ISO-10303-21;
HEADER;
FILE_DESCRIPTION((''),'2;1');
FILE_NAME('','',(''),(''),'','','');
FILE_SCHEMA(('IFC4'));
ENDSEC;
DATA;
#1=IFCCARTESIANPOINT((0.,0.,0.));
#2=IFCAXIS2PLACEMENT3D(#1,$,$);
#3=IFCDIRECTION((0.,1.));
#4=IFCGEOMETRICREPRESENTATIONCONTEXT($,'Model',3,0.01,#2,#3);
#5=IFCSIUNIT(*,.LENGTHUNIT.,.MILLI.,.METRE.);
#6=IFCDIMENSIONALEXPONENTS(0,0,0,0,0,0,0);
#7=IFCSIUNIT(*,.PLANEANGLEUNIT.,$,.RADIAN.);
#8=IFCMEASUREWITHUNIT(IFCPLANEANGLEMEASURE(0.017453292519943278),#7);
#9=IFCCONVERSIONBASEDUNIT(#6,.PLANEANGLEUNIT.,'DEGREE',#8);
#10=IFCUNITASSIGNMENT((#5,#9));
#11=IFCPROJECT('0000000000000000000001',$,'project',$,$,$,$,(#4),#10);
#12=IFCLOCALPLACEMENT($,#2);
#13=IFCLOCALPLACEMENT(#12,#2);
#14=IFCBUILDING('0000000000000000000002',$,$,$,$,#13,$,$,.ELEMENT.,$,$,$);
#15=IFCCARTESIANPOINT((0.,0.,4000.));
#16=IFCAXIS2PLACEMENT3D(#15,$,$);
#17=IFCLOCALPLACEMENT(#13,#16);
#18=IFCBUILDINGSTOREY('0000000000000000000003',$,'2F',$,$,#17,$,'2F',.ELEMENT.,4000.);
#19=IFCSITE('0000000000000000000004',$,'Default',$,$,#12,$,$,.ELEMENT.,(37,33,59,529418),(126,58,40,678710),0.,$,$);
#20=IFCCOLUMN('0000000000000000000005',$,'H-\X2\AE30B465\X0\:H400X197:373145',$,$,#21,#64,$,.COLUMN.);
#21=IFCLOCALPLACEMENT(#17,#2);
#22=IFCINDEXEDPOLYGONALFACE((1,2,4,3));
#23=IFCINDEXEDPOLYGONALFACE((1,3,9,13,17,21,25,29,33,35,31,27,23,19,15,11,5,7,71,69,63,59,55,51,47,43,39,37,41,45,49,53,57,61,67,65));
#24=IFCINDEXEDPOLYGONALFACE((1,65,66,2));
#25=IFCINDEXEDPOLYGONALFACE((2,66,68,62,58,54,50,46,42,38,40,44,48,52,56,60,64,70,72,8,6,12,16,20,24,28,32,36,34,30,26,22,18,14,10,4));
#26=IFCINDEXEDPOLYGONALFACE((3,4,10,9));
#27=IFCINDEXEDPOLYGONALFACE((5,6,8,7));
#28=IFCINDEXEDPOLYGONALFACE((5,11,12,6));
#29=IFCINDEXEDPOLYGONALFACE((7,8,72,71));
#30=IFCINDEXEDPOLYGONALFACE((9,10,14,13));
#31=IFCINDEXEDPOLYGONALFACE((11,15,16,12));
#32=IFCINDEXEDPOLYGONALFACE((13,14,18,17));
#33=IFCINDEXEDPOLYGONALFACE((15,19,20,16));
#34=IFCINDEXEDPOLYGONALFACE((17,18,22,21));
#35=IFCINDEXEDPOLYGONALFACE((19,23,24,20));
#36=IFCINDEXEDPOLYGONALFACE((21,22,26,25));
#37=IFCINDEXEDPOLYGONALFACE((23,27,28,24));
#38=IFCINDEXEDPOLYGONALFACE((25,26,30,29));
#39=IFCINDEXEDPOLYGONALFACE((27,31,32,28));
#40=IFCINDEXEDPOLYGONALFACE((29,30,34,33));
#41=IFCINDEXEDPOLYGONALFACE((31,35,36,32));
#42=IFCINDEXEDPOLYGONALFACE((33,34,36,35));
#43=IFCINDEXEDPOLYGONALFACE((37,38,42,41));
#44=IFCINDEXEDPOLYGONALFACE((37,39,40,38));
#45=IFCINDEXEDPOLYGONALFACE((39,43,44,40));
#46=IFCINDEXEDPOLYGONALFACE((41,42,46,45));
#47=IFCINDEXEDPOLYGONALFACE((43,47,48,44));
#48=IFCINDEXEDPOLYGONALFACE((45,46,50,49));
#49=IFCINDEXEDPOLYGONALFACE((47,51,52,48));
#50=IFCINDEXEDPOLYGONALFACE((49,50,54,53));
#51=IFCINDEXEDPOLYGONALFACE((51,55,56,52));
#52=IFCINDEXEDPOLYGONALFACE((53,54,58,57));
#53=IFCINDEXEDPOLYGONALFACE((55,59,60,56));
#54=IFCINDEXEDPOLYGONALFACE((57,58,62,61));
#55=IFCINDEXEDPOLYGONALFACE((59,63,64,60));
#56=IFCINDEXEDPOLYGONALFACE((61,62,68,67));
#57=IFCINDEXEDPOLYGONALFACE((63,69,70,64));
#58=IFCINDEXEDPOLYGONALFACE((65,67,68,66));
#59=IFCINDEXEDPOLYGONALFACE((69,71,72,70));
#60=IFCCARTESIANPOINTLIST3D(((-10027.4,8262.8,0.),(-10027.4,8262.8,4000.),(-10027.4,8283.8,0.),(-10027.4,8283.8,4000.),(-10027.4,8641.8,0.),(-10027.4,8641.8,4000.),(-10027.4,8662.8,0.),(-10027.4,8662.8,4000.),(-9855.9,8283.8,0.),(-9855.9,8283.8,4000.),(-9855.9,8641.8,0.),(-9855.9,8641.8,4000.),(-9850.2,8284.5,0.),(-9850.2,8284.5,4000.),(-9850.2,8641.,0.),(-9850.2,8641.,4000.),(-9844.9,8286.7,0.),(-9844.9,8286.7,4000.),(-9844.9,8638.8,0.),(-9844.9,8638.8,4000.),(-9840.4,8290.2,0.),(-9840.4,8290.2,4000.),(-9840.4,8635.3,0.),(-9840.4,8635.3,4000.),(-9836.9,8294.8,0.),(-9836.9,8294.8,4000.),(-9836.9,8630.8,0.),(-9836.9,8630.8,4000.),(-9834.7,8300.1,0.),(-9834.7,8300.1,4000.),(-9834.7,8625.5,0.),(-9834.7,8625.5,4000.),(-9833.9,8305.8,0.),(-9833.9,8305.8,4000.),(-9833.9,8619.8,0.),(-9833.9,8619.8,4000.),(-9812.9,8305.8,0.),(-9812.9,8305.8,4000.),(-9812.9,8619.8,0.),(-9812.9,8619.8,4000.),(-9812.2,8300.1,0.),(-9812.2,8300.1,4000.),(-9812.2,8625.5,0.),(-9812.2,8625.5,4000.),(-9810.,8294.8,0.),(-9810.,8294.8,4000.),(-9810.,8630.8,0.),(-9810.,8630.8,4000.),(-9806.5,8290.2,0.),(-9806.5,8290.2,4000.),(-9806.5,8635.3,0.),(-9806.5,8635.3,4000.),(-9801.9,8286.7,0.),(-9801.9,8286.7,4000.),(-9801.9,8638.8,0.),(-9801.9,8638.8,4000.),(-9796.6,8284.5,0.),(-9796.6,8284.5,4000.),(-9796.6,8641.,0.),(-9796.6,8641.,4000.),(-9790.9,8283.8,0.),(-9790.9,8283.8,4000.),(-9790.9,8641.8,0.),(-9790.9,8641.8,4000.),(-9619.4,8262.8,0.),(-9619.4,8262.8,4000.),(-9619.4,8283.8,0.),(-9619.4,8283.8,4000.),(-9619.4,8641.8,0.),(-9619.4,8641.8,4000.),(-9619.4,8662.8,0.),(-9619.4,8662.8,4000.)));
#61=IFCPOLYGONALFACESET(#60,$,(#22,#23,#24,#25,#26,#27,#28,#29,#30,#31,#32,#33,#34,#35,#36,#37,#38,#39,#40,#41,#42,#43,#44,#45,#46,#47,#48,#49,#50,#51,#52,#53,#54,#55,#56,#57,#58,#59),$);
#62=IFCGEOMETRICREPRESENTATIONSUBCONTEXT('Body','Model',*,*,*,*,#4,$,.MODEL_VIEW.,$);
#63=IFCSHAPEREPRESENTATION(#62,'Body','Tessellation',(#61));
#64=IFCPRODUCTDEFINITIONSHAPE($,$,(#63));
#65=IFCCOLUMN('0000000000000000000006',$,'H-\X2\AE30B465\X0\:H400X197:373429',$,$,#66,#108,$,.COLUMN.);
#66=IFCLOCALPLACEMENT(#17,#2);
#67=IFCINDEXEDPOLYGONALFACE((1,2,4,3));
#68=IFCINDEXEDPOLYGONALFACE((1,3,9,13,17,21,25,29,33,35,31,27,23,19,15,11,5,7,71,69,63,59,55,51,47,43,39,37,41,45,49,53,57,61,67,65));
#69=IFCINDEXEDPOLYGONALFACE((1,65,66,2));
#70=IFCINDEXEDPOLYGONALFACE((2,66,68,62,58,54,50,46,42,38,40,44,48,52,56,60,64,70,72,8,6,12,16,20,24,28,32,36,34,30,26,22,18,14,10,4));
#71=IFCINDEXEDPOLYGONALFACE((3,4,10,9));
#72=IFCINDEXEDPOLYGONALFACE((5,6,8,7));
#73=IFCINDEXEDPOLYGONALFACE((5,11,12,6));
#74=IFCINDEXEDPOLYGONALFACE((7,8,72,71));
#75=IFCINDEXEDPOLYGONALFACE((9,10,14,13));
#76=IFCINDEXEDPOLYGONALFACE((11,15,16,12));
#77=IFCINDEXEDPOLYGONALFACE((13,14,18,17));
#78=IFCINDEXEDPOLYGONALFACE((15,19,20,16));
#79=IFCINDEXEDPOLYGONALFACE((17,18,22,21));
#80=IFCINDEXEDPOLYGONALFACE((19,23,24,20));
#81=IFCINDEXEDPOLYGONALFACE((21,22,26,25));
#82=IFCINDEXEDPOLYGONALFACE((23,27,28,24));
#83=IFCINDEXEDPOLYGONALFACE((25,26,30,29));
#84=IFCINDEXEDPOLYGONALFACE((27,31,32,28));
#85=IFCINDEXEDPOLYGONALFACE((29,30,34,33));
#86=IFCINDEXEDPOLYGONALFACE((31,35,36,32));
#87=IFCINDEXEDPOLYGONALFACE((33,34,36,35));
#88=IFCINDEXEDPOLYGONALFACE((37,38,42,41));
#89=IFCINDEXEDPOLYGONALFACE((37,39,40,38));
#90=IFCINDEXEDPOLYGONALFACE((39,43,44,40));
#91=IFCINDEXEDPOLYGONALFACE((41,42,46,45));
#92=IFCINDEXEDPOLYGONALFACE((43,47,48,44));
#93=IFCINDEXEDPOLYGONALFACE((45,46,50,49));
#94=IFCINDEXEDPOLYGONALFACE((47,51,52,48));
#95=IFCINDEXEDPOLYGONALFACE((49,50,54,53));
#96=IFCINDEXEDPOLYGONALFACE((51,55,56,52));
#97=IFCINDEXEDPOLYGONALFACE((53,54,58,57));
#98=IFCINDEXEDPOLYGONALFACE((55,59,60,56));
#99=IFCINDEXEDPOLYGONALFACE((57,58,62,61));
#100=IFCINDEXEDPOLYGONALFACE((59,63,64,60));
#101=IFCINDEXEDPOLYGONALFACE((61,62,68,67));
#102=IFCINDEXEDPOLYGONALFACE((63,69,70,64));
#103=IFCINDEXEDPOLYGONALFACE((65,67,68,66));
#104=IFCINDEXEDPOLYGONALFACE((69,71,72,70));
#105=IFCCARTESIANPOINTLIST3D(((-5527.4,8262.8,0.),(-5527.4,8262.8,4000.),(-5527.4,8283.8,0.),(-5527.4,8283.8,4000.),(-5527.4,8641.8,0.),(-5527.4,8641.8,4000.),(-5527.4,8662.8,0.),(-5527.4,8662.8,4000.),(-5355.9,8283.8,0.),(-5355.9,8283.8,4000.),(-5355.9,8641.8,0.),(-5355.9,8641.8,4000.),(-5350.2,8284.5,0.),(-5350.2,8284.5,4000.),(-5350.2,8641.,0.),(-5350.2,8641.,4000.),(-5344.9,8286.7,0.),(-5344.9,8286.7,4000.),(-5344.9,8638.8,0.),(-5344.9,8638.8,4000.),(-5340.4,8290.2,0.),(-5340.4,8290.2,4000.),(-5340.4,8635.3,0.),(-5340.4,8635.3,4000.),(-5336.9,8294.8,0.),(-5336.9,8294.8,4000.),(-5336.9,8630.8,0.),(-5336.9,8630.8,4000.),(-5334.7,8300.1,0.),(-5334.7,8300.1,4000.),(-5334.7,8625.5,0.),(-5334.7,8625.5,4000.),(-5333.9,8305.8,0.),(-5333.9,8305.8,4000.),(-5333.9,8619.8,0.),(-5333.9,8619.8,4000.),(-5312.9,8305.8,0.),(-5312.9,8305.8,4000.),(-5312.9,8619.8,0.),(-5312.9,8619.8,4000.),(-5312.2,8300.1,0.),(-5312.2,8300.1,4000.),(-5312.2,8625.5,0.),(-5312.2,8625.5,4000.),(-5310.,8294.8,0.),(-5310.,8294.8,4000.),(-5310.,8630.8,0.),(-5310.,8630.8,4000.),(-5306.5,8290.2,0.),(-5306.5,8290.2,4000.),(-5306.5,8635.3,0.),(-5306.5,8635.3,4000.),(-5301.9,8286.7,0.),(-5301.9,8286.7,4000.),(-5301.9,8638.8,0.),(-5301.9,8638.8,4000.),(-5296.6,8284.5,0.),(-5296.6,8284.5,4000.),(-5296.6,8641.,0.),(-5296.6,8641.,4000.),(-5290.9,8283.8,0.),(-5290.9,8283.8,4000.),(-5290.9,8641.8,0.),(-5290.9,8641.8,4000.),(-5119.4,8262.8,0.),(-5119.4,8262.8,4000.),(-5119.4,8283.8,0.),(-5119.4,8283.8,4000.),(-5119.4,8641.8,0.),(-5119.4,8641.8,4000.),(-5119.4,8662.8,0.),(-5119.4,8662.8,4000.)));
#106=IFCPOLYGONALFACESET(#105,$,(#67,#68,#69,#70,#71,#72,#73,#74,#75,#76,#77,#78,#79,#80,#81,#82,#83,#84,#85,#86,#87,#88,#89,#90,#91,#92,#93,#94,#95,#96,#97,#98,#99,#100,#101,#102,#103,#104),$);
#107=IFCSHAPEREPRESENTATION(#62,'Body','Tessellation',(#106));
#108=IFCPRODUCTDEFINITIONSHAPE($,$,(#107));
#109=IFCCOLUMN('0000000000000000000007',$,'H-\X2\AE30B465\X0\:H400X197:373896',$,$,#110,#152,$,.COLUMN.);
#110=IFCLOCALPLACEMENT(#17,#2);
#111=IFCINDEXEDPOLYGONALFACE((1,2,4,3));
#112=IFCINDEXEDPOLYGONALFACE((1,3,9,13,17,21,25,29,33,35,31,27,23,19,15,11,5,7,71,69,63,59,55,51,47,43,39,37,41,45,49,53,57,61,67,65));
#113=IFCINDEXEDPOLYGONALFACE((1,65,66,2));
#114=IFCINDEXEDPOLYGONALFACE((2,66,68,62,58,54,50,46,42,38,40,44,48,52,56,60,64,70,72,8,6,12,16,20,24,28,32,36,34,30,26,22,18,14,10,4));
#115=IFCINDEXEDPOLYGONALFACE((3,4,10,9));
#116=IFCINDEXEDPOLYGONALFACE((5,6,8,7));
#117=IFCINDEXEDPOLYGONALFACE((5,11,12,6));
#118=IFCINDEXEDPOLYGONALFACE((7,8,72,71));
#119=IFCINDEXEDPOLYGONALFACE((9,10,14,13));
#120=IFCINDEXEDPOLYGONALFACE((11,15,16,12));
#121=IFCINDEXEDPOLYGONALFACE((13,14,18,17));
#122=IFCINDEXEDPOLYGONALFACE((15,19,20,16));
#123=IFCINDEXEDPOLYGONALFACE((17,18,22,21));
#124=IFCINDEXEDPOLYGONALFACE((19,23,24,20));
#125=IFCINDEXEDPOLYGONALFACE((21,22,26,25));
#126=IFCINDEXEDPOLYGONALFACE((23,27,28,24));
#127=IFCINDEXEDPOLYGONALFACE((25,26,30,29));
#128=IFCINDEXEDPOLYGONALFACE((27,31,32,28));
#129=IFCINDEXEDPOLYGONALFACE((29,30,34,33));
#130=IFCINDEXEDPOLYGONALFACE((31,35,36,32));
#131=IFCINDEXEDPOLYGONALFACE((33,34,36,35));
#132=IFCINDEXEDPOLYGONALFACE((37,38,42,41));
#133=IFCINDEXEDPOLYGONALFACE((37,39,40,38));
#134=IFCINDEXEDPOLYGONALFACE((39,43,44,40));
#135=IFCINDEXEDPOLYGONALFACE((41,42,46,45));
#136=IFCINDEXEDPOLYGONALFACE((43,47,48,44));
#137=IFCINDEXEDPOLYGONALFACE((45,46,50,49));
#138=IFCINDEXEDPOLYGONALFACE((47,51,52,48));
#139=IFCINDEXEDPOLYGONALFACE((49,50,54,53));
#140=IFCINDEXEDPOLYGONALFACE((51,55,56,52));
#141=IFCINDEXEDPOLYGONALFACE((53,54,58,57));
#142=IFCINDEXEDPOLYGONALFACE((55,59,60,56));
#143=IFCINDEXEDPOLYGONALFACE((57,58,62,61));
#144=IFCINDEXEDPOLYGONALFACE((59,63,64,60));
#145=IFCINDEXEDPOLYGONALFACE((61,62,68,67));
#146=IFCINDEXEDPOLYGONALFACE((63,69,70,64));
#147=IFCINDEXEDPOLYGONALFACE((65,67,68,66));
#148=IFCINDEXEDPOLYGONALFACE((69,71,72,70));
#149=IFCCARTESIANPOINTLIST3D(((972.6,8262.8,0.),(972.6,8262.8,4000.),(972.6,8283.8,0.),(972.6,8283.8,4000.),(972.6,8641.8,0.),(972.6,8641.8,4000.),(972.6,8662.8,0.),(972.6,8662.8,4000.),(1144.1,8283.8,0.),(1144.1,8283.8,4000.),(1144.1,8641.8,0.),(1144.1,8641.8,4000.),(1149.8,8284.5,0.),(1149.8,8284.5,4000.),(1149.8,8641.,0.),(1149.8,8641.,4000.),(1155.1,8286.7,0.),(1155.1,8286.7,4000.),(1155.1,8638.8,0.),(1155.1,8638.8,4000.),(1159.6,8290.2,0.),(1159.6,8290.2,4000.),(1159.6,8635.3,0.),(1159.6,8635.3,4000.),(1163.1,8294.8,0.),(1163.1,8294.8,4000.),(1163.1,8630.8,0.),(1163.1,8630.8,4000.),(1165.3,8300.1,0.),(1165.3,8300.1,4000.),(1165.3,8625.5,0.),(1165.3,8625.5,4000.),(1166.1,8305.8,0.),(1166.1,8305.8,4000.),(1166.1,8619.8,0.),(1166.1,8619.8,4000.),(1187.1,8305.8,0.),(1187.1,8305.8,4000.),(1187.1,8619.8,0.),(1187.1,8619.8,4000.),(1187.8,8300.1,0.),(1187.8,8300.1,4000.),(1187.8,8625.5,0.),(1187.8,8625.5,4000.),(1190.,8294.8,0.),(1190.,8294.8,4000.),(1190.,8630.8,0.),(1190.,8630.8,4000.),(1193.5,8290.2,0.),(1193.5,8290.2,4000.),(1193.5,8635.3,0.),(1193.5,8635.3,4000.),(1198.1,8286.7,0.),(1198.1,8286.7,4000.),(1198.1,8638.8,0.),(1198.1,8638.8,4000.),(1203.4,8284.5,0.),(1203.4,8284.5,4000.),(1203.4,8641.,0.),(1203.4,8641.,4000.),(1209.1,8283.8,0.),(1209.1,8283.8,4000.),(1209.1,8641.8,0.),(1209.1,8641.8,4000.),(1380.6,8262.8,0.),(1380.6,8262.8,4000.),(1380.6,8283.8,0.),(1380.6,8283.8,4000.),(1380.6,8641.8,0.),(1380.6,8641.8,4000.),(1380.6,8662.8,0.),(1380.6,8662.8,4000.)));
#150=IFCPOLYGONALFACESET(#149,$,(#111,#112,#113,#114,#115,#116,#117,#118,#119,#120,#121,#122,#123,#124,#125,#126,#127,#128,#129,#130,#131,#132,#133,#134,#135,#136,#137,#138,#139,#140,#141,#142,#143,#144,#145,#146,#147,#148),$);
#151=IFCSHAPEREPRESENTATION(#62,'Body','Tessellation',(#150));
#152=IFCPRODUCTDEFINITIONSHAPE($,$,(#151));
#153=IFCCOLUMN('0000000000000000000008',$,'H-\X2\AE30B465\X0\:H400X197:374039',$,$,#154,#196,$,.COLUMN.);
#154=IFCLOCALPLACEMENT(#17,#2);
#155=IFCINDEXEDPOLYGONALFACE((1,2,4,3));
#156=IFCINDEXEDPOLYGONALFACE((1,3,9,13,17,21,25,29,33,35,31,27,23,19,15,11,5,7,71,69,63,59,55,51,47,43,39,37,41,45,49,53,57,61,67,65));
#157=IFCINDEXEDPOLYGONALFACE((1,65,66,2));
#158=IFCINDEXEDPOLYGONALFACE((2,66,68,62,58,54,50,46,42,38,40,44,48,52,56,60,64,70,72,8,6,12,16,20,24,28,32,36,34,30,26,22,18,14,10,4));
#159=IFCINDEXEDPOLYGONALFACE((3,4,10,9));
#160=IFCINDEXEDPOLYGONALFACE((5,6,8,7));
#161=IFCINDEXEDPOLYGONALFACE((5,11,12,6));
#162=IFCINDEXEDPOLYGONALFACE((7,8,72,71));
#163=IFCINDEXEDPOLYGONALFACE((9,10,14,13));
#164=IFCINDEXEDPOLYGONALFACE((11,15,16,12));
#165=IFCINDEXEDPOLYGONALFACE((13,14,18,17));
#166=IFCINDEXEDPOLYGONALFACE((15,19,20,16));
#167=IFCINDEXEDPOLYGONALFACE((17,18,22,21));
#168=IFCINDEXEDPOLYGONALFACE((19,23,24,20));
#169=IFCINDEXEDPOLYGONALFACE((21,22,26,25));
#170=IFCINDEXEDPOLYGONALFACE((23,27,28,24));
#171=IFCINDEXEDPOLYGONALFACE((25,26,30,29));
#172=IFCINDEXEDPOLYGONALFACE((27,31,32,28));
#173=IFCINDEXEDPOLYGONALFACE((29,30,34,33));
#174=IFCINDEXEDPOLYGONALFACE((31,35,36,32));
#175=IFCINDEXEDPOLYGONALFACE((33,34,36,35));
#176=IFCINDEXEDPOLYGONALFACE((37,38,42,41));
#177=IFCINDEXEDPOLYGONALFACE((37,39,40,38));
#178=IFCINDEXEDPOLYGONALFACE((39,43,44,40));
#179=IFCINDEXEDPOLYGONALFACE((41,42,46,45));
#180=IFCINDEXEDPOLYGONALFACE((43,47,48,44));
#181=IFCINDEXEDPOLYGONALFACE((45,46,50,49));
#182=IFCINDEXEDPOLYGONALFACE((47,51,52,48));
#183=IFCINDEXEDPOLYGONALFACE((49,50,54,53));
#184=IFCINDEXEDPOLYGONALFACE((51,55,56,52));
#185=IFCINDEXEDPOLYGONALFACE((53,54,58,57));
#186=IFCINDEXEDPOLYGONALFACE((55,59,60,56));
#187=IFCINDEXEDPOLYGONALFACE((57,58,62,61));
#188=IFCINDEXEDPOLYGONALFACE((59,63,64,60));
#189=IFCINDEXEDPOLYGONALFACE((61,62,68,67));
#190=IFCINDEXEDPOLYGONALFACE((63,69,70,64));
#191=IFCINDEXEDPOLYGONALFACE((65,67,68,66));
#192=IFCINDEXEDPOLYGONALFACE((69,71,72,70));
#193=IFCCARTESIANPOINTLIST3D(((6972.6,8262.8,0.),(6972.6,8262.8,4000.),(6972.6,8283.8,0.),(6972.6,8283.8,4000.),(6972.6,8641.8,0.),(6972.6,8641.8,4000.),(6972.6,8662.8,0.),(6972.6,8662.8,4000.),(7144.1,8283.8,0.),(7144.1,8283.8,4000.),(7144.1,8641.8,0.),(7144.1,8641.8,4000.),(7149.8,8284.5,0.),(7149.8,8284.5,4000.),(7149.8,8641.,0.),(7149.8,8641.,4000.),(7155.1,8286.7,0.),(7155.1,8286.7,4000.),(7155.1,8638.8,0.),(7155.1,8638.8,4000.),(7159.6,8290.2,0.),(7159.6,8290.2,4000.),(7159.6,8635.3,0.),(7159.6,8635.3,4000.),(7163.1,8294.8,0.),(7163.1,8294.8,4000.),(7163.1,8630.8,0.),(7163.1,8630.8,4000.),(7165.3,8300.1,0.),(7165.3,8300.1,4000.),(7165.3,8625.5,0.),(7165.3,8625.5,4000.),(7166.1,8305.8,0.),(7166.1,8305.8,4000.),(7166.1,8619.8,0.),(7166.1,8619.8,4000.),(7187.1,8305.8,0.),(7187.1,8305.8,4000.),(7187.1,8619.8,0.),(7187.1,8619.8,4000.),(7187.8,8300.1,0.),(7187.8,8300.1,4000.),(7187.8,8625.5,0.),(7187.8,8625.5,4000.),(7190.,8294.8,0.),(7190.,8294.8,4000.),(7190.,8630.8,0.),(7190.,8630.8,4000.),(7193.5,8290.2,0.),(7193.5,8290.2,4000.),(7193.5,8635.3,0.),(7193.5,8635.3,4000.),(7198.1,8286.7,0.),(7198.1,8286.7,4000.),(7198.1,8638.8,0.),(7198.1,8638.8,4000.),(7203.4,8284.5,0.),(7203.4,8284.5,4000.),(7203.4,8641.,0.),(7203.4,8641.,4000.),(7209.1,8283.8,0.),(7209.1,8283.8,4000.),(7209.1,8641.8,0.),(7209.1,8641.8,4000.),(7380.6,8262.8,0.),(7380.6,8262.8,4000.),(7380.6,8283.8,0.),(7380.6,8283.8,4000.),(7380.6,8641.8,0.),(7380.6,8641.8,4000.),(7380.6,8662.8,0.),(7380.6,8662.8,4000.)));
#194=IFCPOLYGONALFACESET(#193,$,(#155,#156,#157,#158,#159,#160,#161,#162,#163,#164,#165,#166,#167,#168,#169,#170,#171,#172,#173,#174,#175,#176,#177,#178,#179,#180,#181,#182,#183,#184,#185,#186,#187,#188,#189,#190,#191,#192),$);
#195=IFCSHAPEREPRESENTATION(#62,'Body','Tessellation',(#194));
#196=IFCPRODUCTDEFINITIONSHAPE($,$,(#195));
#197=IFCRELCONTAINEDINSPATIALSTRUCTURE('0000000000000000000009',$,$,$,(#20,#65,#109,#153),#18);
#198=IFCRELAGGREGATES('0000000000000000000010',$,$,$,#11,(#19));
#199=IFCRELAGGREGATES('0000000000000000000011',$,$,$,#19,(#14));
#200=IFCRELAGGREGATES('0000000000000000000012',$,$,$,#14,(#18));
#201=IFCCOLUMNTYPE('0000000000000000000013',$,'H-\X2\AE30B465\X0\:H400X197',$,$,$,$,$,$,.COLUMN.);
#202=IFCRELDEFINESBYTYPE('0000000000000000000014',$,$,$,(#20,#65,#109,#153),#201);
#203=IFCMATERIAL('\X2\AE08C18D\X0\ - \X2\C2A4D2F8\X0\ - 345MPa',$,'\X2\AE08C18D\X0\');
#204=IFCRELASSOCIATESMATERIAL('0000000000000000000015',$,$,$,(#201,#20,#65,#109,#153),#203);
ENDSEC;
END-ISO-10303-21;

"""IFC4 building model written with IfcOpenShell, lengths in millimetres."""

from ifc_helpers import new_model, entity, si_unit, converted_unit, direction, frame, origin, place, context, subcontext, project, spatial, line, arc, indexed_curve, outline, extrude, source, transform, mapped, material, type_object, type_shapes, element, save


model = new_model("IFC4")

# Units and contexts
model_context = context("Model", 3, precision=0.01, world=origin(), true_north=direction((0.0, 1.0)))
body_context = subcontext(model_context, "Body", "Model", "MODEL_VIEW")
ifc_project = project(units=[si_unit("LENGTHUNIT", "METRE", prefix="MILLI"), converted_unit("PLANEANGLEUNIT", "DEGREE", entity("IfcPlaneAngleMeasure", 0.017453292519943278), si_unit("PLANEANGLEUNIT", "RADIAN"), dimensions=[0, 0, 0, 0, 0, 0, 0])], contexts=[model_context])

# Site, building, storey
site_placement = place(None, origin())
site = spatial("IfcSite", under=ifc_project, at=site_placement, Name="Default", CompositionType="ELEMENT", RefLatitude=(37, 33, 59, 529418), RefLongitude=(126, 58, 40, 678710), RefElevation=0.0)
building_placement = place(site_placement, origin())
building = spatial("IfcBuilding", under=site, at=building_placement, CompositionType="ELEMENT")
storey_placement = place(building_placement, frame((0.0, 0.0, 4000.0)))
storey = spatial("IfcBuildingStorey", under=building, at=storey_placement, Name="2F", LongName="2F", CompositionType="ELEMENT", Elevation=4000.0)

# Columns
ifc_material = material(Name="금속 - 스틸 - 345MPa", Category="금속")
column_type = type_object("IfcColumnType", Name="H-기둥:H400X197", PredefinedType="COLUMN", material=ifc_material)
shared_shape_1 = source(origin(), body_context, "Body", "SweptSolid", [
    extrude(outline(indexed_curve([(-204.0, -200.0), (204.0, -200.0), (204.0, -179.0), (32.5, -179.0), (16.9, -172.6), (10.5, -157.0), (10.5, 157.0), (16.9, 172.6), (32.5, 179.0), (204.0, 179.0), (204.0, 200.0), (-204.0, 200.0), (-204.0, 179.0), (-32.5, 179.0), (-16.9, 172.6), (-10.5, 157.0), (-10.5, -157.0), (-16.9, -172.6), (-32.5, -179.0), (-204.0, -179.0)], segments=[line(1, 2, 3, 4), arc(4, 5, 6), line(6, 7), arc(7, 8, 9), line(9, 10, 11, 12, 13, 14), arc(14, 15, 16), line(16, 17), arc(17, 18, 19), line(19, 20, 1)], self_intersect=False)), frame((0.0, 0.0, 4000.0), z_axis=(0.0, 0.0, 1.0), x_axis=(-1.0, 0.0, 0.0)), (0.0, 0.0, 1.0), 4000.0),
])
type_shapes(column_type, [shared_shape_1])
for number, where, name in (
    (1, (-9823.4, 8462.8, -4000.0), "H-기둥:H400X197:373145"),
    (2, (-5323.4, 8462.8, -4000.0), "H-기둥:H400X197:373429"),
    (3, (1176.6, 8462.8, -4000.0), "H-기둥:H400X197:373896"),
    (4, (7176.6, 8462.8, -4000.0), "H-기둥:H400X197:374039"),
):
    element("IfcColumn", number, at=place(storey_placement, frame(where)), inside=storey, type_object=column_type, material=ifc_material, Name=name, PredefinedType="COLUMN", context=body_context, shape_type="MappedRepresentation", body=[
        mapped(shared_shape_1, transform((0.0, 0.0, 0.0), scale=1.0)),
    ])

save(model, "model.ifc")
